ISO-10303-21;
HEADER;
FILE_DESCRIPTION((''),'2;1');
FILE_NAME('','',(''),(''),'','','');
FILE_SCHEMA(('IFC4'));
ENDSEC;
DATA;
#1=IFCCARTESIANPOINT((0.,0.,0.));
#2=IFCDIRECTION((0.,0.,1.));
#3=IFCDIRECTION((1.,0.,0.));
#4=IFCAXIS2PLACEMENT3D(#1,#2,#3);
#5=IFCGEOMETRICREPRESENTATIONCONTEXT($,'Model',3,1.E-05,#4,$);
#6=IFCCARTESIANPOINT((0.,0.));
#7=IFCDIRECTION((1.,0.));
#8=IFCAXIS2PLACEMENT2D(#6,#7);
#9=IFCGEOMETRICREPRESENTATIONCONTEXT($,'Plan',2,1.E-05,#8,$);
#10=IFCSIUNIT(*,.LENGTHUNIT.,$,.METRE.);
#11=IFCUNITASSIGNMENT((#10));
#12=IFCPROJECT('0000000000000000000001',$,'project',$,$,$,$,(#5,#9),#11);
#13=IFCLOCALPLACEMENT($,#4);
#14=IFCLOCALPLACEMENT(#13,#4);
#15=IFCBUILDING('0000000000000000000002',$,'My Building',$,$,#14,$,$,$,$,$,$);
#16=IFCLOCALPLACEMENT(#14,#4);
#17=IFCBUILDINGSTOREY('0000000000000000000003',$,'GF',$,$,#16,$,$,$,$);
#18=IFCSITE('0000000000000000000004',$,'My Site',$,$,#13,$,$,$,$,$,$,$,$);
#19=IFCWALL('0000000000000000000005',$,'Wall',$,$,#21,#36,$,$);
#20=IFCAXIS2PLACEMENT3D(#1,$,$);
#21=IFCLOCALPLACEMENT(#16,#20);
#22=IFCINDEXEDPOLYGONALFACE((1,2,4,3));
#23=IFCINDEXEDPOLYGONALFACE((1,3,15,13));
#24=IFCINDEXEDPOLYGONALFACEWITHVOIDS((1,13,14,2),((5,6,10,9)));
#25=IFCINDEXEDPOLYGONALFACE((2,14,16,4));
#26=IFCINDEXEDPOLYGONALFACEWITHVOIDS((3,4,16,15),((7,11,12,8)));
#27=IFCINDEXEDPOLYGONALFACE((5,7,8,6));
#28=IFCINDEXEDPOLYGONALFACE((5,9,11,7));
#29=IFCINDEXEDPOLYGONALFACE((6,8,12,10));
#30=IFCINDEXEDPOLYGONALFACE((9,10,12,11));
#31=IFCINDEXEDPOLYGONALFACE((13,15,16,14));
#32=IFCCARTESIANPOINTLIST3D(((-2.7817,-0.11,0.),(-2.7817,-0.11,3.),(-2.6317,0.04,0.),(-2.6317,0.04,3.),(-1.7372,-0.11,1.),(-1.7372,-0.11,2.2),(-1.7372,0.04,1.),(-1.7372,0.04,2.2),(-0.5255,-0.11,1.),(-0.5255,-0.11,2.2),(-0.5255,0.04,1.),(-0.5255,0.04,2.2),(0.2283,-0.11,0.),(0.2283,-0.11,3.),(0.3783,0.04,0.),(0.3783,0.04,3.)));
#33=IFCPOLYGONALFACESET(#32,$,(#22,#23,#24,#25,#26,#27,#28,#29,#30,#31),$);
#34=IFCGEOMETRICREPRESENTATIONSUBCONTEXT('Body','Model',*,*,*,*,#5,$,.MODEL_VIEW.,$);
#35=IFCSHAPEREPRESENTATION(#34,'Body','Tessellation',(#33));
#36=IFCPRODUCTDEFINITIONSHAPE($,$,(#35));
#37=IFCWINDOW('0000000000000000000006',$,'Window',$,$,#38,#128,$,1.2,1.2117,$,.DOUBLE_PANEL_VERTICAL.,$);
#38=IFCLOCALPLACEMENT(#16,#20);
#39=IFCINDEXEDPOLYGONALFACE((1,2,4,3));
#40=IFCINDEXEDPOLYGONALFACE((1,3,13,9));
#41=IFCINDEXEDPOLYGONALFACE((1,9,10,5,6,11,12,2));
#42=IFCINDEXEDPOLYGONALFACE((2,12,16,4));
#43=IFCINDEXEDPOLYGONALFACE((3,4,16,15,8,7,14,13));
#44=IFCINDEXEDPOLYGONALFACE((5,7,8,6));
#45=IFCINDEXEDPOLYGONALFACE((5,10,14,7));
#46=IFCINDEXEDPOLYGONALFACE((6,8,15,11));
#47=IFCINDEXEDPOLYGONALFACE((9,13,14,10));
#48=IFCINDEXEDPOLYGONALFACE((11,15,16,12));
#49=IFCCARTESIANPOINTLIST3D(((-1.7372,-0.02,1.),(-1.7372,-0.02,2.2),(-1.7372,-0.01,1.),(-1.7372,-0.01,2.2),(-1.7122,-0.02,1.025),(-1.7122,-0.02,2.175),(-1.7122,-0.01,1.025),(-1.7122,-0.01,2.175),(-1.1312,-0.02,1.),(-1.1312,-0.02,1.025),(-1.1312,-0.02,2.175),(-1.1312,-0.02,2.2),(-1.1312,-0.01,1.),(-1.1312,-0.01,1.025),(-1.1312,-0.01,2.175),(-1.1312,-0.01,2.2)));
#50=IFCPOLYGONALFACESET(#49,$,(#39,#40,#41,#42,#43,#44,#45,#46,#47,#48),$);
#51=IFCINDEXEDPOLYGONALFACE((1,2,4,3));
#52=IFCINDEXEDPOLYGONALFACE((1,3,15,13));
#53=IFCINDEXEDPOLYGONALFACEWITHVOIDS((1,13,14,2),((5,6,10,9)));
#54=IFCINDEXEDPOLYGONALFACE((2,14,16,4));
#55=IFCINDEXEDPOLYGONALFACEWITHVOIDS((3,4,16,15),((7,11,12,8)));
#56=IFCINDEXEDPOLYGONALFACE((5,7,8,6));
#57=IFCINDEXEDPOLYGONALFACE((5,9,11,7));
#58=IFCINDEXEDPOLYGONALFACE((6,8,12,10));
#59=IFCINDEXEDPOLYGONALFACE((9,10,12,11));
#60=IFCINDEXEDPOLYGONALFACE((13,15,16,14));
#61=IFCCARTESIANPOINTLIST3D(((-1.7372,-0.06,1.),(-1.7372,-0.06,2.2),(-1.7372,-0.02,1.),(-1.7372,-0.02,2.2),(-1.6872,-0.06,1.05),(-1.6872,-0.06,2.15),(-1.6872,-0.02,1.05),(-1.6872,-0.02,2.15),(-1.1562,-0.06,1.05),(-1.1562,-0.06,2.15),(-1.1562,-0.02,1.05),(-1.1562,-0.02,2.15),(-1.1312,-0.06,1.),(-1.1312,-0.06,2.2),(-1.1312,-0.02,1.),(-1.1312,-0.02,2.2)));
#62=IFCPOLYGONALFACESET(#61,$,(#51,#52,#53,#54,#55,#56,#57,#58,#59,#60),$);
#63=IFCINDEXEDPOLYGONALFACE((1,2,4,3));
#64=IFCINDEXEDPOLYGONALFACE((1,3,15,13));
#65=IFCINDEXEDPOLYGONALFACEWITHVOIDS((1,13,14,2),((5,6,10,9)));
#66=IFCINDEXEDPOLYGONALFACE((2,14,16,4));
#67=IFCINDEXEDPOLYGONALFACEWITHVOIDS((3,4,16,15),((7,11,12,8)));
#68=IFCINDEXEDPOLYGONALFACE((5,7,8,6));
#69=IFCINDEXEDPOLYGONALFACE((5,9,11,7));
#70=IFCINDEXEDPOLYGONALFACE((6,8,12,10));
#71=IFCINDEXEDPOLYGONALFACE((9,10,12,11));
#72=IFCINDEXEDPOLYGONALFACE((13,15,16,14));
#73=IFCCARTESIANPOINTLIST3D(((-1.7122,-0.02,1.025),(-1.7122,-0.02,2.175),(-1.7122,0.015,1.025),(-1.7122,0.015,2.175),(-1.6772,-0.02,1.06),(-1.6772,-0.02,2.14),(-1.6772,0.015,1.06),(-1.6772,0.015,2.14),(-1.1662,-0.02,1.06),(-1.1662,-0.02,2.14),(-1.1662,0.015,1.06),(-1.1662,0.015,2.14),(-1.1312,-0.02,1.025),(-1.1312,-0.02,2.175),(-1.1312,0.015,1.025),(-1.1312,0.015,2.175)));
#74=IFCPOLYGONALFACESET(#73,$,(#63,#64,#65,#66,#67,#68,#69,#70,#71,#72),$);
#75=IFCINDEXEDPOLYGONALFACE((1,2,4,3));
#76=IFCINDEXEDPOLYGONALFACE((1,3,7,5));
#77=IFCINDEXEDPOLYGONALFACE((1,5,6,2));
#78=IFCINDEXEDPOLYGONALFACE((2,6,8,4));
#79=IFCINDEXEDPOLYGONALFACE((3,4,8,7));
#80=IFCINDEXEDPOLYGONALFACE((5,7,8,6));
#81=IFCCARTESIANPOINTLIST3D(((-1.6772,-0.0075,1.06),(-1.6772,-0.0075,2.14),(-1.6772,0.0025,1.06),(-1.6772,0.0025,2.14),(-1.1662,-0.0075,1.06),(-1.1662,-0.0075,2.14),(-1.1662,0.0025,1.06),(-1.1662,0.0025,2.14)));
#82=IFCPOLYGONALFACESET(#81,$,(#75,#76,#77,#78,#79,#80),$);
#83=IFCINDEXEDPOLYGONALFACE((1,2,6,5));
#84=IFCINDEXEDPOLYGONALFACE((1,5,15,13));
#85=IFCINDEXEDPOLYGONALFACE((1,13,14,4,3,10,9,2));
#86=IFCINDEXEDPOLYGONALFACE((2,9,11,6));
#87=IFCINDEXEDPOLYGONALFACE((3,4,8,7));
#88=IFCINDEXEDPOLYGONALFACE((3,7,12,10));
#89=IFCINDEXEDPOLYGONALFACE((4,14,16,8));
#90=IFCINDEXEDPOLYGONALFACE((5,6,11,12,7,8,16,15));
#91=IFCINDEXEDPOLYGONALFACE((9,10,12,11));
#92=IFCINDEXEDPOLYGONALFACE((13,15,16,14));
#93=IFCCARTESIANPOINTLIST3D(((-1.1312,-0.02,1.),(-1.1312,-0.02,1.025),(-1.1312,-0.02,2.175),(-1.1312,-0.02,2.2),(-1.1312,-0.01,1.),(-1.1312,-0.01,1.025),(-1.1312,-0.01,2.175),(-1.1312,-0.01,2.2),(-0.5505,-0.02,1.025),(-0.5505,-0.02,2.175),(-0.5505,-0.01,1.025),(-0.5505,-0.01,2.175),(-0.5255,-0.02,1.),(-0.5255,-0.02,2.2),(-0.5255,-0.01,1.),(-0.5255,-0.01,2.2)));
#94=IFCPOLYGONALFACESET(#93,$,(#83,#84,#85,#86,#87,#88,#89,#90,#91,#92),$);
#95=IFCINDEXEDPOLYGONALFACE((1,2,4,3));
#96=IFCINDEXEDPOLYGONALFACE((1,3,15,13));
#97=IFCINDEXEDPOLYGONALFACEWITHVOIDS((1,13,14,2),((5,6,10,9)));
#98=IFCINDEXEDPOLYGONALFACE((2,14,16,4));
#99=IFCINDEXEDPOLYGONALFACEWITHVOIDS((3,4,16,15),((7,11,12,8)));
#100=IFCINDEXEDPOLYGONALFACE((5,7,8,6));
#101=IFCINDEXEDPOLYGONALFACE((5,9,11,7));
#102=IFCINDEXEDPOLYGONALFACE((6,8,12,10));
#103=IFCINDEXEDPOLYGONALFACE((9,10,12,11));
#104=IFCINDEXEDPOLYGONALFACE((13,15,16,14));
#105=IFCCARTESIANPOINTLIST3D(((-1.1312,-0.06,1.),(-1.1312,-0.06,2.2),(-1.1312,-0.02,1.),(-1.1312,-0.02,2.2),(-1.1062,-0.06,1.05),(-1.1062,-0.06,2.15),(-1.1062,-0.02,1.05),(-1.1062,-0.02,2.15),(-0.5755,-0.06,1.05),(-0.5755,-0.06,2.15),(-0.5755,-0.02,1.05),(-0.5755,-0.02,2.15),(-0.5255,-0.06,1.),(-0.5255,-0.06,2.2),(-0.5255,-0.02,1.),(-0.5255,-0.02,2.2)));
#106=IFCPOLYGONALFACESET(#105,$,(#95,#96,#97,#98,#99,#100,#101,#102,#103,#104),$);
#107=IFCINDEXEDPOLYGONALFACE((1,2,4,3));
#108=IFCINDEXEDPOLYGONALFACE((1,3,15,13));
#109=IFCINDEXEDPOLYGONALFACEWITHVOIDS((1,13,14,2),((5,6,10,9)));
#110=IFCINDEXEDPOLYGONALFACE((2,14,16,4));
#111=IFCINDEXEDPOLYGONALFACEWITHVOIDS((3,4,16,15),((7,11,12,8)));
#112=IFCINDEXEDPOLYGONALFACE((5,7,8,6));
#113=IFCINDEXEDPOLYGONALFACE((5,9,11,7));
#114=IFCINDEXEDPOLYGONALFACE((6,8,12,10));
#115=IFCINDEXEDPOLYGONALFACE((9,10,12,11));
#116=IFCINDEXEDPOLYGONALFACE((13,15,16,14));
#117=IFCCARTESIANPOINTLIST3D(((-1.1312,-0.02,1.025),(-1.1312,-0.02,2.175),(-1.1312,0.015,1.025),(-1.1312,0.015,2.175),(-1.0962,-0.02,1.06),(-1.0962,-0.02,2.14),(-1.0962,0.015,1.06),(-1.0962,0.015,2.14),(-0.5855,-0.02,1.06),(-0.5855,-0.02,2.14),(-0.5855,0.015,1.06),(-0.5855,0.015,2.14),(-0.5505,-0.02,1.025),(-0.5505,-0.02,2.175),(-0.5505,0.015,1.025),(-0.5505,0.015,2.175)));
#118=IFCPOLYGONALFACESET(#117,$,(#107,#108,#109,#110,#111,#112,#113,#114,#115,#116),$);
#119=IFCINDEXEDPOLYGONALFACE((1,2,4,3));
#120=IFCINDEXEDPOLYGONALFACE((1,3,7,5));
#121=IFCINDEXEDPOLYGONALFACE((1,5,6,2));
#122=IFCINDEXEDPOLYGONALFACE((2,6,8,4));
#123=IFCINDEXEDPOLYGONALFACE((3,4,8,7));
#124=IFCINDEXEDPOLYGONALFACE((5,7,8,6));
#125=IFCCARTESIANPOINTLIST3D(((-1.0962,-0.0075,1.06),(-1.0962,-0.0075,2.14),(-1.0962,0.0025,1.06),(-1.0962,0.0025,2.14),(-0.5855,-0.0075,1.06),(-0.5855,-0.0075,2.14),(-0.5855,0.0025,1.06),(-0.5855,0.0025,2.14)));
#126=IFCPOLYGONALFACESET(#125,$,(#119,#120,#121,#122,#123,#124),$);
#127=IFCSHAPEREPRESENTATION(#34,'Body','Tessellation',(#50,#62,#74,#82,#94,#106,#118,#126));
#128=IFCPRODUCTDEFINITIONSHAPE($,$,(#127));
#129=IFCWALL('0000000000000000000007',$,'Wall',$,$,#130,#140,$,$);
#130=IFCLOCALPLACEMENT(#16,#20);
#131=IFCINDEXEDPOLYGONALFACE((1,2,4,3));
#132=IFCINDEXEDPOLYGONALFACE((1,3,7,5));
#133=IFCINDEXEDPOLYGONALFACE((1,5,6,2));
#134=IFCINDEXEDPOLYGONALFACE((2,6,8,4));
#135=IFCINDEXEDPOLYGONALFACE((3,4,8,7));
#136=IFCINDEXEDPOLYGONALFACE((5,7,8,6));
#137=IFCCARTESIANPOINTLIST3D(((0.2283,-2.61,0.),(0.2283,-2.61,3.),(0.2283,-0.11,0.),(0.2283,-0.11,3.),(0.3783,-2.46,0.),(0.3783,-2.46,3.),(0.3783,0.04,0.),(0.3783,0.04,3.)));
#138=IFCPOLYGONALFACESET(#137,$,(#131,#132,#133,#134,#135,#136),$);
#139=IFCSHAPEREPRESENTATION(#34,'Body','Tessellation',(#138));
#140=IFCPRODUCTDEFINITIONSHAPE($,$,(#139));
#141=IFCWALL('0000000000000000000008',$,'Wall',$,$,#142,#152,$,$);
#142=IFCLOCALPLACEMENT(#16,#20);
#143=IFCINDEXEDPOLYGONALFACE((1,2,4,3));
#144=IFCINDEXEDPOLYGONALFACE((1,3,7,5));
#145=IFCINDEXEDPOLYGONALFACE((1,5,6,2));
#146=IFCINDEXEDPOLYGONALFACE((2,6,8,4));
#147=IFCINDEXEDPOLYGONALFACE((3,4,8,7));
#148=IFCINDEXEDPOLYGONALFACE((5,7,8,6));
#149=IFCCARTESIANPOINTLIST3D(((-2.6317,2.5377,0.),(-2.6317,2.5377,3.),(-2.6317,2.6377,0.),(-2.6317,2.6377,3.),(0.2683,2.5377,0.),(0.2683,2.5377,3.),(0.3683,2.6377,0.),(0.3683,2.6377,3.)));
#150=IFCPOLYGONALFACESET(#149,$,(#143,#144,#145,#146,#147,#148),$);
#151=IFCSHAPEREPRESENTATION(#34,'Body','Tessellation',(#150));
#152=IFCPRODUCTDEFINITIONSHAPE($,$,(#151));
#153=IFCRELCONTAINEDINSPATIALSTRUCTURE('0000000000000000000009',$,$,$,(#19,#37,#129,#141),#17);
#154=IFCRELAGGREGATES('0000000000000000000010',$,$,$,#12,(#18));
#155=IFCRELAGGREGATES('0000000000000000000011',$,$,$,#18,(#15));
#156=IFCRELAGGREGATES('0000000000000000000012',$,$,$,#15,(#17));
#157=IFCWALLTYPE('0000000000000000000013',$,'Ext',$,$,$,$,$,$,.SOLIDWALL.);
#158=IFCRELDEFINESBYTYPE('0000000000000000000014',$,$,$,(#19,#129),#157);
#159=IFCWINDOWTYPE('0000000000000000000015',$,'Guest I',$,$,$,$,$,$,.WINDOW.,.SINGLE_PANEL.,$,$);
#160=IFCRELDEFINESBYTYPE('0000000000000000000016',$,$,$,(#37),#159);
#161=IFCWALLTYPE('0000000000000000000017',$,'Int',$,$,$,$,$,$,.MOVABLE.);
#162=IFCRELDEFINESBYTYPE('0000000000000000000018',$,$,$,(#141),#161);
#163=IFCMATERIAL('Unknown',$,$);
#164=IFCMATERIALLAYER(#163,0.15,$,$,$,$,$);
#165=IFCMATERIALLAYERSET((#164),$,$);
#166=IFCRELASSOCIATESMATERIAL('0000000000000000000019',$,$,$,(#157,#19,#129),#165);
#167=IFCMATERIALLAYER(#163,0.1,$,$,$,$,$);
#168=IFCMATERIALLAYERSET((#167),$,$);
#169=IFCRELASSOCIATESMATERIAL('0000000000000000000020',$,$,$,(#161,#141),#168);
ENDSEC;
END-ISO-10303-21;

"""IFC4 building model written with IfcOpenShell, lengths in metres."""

from ifc_helpers import new_model, entity, si_unit, frame, origin_with_axes, origin_2d_with_axis, place, context, subcontext, project, spatial, line, indexed_curve, outline, extrude, shape, source, transform, mapped, material, layer, layer_set, layer_usage, type_object, type_shapes, element, fill, save


model = new_model("IFC4")

# Units and contexts
model_context = context("Model", 3, precision=1e-05, world=origin_with_axes())
plan_context = context("Plan", 2, precision=1e-05, world=origin_2d_with_axis())
body_context_1 = subcontext(model_context, "Body", "Model", "MODEL_VIEW")
body_context_2 = subcontext(plan_context, "Body", "Plan", "PLAN_VIEW")
ifc_project = project(units=[si_unit("LENGTHUNIT", "METRE")], contexts=[model_context, plan_context])

# Site, building, storey
site_placement = place(None, origin_with_axes())
site = spatial("IfcSite", under=ifc_project, at=site_placement, Name="My Site")
building_placement = place(site_placement, origin_with_axes())
building = spatial("IfcBuilding", under=site, at=building_placement, Name="My Building")
storey_placement = place(building_placement, origin_with_axes())
storey = spatial("IfcBuildingStorey", under=building, at=storey_placement, Name="GF")

# Shared definitions
ifc_material = material(Name="Unknown")

# Shared definitions
ifc_layer_1 = layer(ifc_material, 0.15)
ifc_layer_set_1 = layer_set([ifc_layer_1])
wall_type_1 = type_object("IfcWallType", Name="Ext", PredefinedType="SOLIDWALL", material=ifc_layer_set_1)

# Wall, opening, window
ifc_layer_usage_1 = layer_usage(ifc_layer_set_1, "AXIS2", "POSITIVE", 0.0)
wall_1_placement = place(storey_placement, frame((-2.7817, -0.11, 0.0), z_axis=(0.0, 0.0, 1.0), x_axis=(1.0, 0.0, 0.0)))
wall_1 = element("IfcWall", 1, at=wall_1_placement, inside=storey, type_object=wall_type_1, material=ifc_layer_usage_1, Name="Wall", context=body_context_1, shape_type="SweptSolid", body=[
    extrude(outline(indexed_curve([(0.0, 0.0), (0.15, 0.15), (3.16, 0.15), (3.01, 0.0)], segments=[line(1, 2, 3, 4, 1)])), origin_with_axes(), (0.0, 0.0, 1.0), 3.0),
])
shared_shape_1 = source(origin_with_axes(), body_context_1, "Body", "SweptSolid", [
    extrude(outline(indexed_curve([(0.0, 0.0), (1.2117, 0.0), (1.2117, 1.2), (0.0, 1.2)], segments=[line(1, 2, 3, 4, 1)])), frame((0.0, -0.6, 0.0), z_axis=(0.0, -1.0, 0.0), x_axis=(1.0, 0.0, 0.0)), (0.0, 0.0, -1.0), 1.2),
])
opening_1_placement = place(wall_1_placement, frame((1.0445, 0.0, 1.0), z_axis=(0.0, 0.0, 1.0), x_axis=(1.0, 0.0, 0.0)))
opening_1 = element("IfcOpeningElement", 2, at=opening_1_placement, cuts=wall_1, PredefinedType="OPENING", context=body_context_1, shape_type="MappedRepresentation", body=[
    mapped(shared_shape_1, transform((0.0, 0.0, 0.0), x_axis=(1.0, 0.0, 0.0), y_axis=(0.0, 1.0, 0.0), z_axis=(0.0, 0.0, 1.0), scale=1.0)),
])
window_type_1 = type_object("IfcWindowType", Name="Guest I", PartitioningType="SINGLE_PANEL", PredefinedType="WINDOW")
shared_shape_2 = source(origin_with_axes(), body_context_1, "Body", "SweptSolid", [
    extrude(outline(indexed_curve([(0.606, 0.0), (0.0, 0.0), (0.0, 1.2), (0.606, 1.2), (0.606, 1.175), (0.025, 1.175), (0.025, 0.025), (0.606, 0.025)], segments=[line(1, 2, 3, 4, 5, 6, 7, 8, 1)])), frame((0.0, 0.09, 0.0), z_axis=(0.0, -1.0, 0.0), x_axis=(1.0, 0.0, 0.0)), (0.0, 0.0, -1.0), 0.01),
    extrude(outline(indexed_curve([(0.0, 0.0), (0.606, 0.0), (0.606, 1.2), (0.0, 1.2)], segments=[line(1, 2, 3, 4, 1)]), holes=[indexed_curve([(0.05, 0.05), (0.581, 0.05), (0.581, 1.15), (0.05, 1.15)], segments=[line(1, 2, 3, 4, 1)])]), frame((0.0, 0.05, 0.0), z_axis=(0.0, -1.0, 0.0), x_axis=(1.0, 0.0, 0.0)), (0.0, 0.0, -1.0), 0.04),
    extrude(outline(indexed_curve([(0.0, 0.0), (0.581, 0.0), (0.581, 1.15), (0.0, 1.15)], segments=[line(1, 2, 3, 4, 1)]), holes=[indexed_curve([(0.035, 0.035), (0.546, 0.035), (0.546, 1.115), (0.035, 1.115)], segments=[line(1, 2, 3, 4, 1)])]), frame((0.025, 0.09, 0.025), z_axis=(0.0, -1.0, 0.0), x_axis=(1.0, 0.0, 0.0)), (0.0, 0.0, -1.0), 0.035),
    extrude(outline(indexed_curve([(0.035, 0.035), (0.546, 0.035), (0.546, 1.115), (0.035, 1.115)], segments=[line(1, 2, 3, 4, 1)])), frame((0.025, 0.1025, 0.025), z_axis=(0.0, -1.0, 0.0), x_axis=(1.0, 0.0, 0.0)), (0.0, 0.0, -1.0), 0.01),
    extrude(outline(indexed_curve([(0.0, 1.2), (0.6057, 1.2), (0.6057, 0.0), (0.0, 0.0), (0.0, 0.025), (0.5807, 0.025), (0.5807, 1.175), (0.0, 1.175)], segments=[line(1, 2, 3, 4, 5, 6, 7, 8, 1)])), frame((0.606, 0.09, 0.0), z_axis=(0.0, -1.0, 0.0), x_axis=(1.0, 0.0, 0.0)), (0.0, 0.0, -1.0), 0.01),
    extrude(outline(indexed_curve([(0.0, 0.0), (0.6057, 0.0), (0.6057, 1.2), (0.0, 1.2)], segments=[line(1, 2, 3, 4, 1)]), holes=[indexed_curve([(0.025, 0.05), (0.5557, 0.05), (0.5557, 1.15), (0.025, 1.15)], segments=[line(1, 2, 3, 4, 1)])]), frame((0.606, 0.05, 0.0), z_axis=(0.0, -1.0, 0.0), x_axis=(1.0, 0.0, 0.0)), (0.0, 0.0, -1.0), 0.04),
    extrude(outline(indexed_curve([(0.0, 0.0), (0.5807, 0.0), (0.5807, 1.15), (0.0, 1.15)], segments=[line(1, 2, 3, 4, 1)]), holes=[indexed_curve([(0.035, 0.035), (0.5457, 0.035), (0.5457, 1.115), (0.035, 1.115)], segments=[line(1, 2, 3, 4, 1)])]), frame((0.606, 0.09, 0.025), z_axis=(0.0, -1.0, 0.0), x_axis=(1.0, 0.0, 0.0)), (0.0, 0.0, -1.0), 0.035),
    extrude(outline(indexed_curve([(0.035, 0.035), (0.5457, 0.035), (0.5457, 1.115), (0.035, 1.115)], segments=[line(1, 2, 3, 4, 1)])), frame((0.606, 0.1025, 0.025), z_axis=(0.0, -1.0, 0.0), x_axis=(1.0, 0.0, 0.0)), (0.0, 0.0, -1.0), 0.01),
])
shared_shape_3 = source(origin_with_axes(), body_context_2, "Body", "Curve2D", [
    entity("IfcIndexedPolyCurve", entity("IfcCartesianPointList2D", [[0.05, 0.05], [0.581, 0.05]])),
    entity("IfcIndexedPolyCurve", entity("IfcCartesianPointList2D", [[0.0, 0.1], [0.025, 0.1], [0.025, 0.09], [0.05, 0.09], [0.05, 0.05], [0.0, 0.05]]), [entity("IfcLineIndex", [1, 2, 3, 4, 5, 6, 1])]),
    entity("IfcIndexedPolyCurve", entity("IfcCartesianPointList2D", [[0.606, 0.1], [0.606, 0.1], [0.606, 0.09], [0.581, 0.09], [0.581, 0.05], [0.606, 0.05]])),
    entity("IfcIndexedPolyCurve", entity("IfcCartesianPointList2D", [[0.025, 0.09], [0.06, 0.09], [0.06, 0.125], [0.025, 0.125]]), [entity("IfcLineIndex", [1, 2, 3, 4, 1])]),
    entity("IfcIndexedPolyCurve", entity("IfcCartesianPointList2D", [[0.606, 0.09], [0.571, 0.09], [0.571, 0.125], [0.606, 0.125]]), [entity("IfcLineIndex", [1, 2, 3, 4, 1])]),
    entity("IfcIndexedPolyCurve", entity("IfcCartesianPointList2D", [[0.06, 0.09], [0.571, 0.09]])),
    entity("IfcIndexedPolyCurve", entity("IfcCartesianPointList2D", [[0.06, 0.125], [0.571, 0.125]])),
    entity("IfcIndexedPolyCurve", entity("IfcCartesianPointList2D", [[0.06, 0.1075], [0.571, 0.1075]])),
    entity("IfcIndexedPolyCurve", entity("IfcCartesianPointList2D", [[0.631, 0.05], [1.1617, 0.05]])),
    entity("IfcIndexedPolyCurve", entity("IfcCartesianPointList2D", [[0.606, 0.1], [0.606, 0.1], [0.606, 0.09], [0.631, 0.09], [0.631, 0.05], [0.606, 0.05]])),
    entity("IfcIndexedPolyCurve", entity("IfcCartesianPointList2D", [[1.2117, 0.1], [1.1867, 0.1], [1.1867, 0.09], [1.1617, 0.09], [1.1617, 0.05], [1.2117, 0.05]]), [entity("IfcLineIndex", [1, 2, 3, 4, 5, 6, 1])]),
    entity("IfcIndexedPolyCurve", entity("IfcCartesianPointList2D", [[0.606, 0.09], [0.641, 0.09], [0.641, 0.125], [0.606, 0.125]]), [entity("IfcLineIndex", [1, 2, 3, 4, 1])]),
    entity("IfcIndexedPolyCurve", entity("IfcCartesianPointList2D", [[1.1867, 0.09], [1.1517, 0.09], [1.1517, 0.125], [1.1867, 0.125]]), [entity("IfcLineIndex", [1, 2, 3, 4, 1])]),
    entity("IfcIndexedPolyCurve", entity("IfcCartesianPointList2D", [[0.641, 0.09], [1.1517, 0.09]])),
    entity("IfcIndexedPolyCurve", entity("IfcCartesianPointList2D", [[0.641, 0.125], [1.1517, 0.125]])),
    entity("IfcIndexedPolyCurve", entity("IfcCartesianPointList2D", [[0.641, 0.1075], [1.1517, 0.1075]])),
])
type_shapes(window_type_1, [shared_shape_2, shared_shape_3])
window_1_placement = place(opening_1_placement, origin_with_axes())
window_1 = element("IfcWindow", 3, at=window_1_placement, inside=storey, type_object=window_type_1, Name="Window", OverallHeight=1.2, OverallWidth=1.2117, PartitioningType="DOUBLE_PANEL_VERTICAL", shapes=[
    shape(body_context_1, "Body", "MappedRepresentation", [mapped(shared_shape_2, transform((0.0, 0.0, 0.0), x_axis=(1.0, 0.0, 0.0), y_axis=(0.0, 1.0, 0.0), z_axis=(0.0, 0.0, 1.0), scale=1.0))]),
    shape(body_context_2, "Body", "MappedRepresentation", [mapped(shared_shape_3, transform((0.0, 0.0, 0.0), x_axis=(1.0, 0.0, 0.0), y_axis=(0.0, 1.0, 0.0), z_axis=(0.0, 0.0, 1.0), scale=1.0))]),
])
fill(opening_1, window_1)

# Walls
ifc_layer_usage_2 = layer_usage(ifc_layer_set_1, "AXIS2", "POSITIVE", 0.0)
wall_2_placement = place(storey_placement, frame((0.2283, -0.11, 0.0), z_axis=(0.0, 0.0, 1.0), x_axis=(0.0, -1.0, 0.0)))
element("IfcWall", 4, at=wall_2_placement, inside=storey, type_object=wall_type_1, material=ifc_layer_usage_2, Name="Wall", context=body_context_1, shape_type="SweptSolid", body=[
    extrude(outline(indexed_curve([(0.0, 0.0), (-0.15, 0.15), (2.35, 0.15), (2.5, 0.0)], segments=[line(1, 2, 3, 4, 1)])), origin_with_axes(), (0.0, 0.0, 1.0), 3.0),
])
ifc_layer_2 = layer(ifc_material, 0.1)
ifc_layer_set_2 = layer_set([ifc_layer_2])
ifc_layer_usage_3 = layer_usage(ifc_layer_set_2, "AXIS2", "POSITIVE", 0.0)
wall_type_2 = type_object("IfcWallType", Name="Int", PredefinedType="MOVABLE", material=ifc_layer_set_2)
wall_3_placement = place(storey_placement, frame((-2.6317, 2.5377, 0.0), z_axis=(0.0, 0.0, 1.0), x_axis=(1.0, 0.0, 0.0)))
element("IfcWall", 5, at=wall_3_placement, inside=storey, type_object=wall_type_2, material=ifc_layer_usage_3, Name="Wall", context=body_context_1, shape_type="SweptSolid", body=[
    extrude(outline(indexed_curve([(0.0, 0.0), (0.0, 0.1), (3.0, 0.1), (2.9, 0.0)], segments=[line(1, 2, 3, 4, 1)])), origin_with_axes(), (0.0, 0.0, 1.0), 3.0),
])

save(model, "model.ifc")
